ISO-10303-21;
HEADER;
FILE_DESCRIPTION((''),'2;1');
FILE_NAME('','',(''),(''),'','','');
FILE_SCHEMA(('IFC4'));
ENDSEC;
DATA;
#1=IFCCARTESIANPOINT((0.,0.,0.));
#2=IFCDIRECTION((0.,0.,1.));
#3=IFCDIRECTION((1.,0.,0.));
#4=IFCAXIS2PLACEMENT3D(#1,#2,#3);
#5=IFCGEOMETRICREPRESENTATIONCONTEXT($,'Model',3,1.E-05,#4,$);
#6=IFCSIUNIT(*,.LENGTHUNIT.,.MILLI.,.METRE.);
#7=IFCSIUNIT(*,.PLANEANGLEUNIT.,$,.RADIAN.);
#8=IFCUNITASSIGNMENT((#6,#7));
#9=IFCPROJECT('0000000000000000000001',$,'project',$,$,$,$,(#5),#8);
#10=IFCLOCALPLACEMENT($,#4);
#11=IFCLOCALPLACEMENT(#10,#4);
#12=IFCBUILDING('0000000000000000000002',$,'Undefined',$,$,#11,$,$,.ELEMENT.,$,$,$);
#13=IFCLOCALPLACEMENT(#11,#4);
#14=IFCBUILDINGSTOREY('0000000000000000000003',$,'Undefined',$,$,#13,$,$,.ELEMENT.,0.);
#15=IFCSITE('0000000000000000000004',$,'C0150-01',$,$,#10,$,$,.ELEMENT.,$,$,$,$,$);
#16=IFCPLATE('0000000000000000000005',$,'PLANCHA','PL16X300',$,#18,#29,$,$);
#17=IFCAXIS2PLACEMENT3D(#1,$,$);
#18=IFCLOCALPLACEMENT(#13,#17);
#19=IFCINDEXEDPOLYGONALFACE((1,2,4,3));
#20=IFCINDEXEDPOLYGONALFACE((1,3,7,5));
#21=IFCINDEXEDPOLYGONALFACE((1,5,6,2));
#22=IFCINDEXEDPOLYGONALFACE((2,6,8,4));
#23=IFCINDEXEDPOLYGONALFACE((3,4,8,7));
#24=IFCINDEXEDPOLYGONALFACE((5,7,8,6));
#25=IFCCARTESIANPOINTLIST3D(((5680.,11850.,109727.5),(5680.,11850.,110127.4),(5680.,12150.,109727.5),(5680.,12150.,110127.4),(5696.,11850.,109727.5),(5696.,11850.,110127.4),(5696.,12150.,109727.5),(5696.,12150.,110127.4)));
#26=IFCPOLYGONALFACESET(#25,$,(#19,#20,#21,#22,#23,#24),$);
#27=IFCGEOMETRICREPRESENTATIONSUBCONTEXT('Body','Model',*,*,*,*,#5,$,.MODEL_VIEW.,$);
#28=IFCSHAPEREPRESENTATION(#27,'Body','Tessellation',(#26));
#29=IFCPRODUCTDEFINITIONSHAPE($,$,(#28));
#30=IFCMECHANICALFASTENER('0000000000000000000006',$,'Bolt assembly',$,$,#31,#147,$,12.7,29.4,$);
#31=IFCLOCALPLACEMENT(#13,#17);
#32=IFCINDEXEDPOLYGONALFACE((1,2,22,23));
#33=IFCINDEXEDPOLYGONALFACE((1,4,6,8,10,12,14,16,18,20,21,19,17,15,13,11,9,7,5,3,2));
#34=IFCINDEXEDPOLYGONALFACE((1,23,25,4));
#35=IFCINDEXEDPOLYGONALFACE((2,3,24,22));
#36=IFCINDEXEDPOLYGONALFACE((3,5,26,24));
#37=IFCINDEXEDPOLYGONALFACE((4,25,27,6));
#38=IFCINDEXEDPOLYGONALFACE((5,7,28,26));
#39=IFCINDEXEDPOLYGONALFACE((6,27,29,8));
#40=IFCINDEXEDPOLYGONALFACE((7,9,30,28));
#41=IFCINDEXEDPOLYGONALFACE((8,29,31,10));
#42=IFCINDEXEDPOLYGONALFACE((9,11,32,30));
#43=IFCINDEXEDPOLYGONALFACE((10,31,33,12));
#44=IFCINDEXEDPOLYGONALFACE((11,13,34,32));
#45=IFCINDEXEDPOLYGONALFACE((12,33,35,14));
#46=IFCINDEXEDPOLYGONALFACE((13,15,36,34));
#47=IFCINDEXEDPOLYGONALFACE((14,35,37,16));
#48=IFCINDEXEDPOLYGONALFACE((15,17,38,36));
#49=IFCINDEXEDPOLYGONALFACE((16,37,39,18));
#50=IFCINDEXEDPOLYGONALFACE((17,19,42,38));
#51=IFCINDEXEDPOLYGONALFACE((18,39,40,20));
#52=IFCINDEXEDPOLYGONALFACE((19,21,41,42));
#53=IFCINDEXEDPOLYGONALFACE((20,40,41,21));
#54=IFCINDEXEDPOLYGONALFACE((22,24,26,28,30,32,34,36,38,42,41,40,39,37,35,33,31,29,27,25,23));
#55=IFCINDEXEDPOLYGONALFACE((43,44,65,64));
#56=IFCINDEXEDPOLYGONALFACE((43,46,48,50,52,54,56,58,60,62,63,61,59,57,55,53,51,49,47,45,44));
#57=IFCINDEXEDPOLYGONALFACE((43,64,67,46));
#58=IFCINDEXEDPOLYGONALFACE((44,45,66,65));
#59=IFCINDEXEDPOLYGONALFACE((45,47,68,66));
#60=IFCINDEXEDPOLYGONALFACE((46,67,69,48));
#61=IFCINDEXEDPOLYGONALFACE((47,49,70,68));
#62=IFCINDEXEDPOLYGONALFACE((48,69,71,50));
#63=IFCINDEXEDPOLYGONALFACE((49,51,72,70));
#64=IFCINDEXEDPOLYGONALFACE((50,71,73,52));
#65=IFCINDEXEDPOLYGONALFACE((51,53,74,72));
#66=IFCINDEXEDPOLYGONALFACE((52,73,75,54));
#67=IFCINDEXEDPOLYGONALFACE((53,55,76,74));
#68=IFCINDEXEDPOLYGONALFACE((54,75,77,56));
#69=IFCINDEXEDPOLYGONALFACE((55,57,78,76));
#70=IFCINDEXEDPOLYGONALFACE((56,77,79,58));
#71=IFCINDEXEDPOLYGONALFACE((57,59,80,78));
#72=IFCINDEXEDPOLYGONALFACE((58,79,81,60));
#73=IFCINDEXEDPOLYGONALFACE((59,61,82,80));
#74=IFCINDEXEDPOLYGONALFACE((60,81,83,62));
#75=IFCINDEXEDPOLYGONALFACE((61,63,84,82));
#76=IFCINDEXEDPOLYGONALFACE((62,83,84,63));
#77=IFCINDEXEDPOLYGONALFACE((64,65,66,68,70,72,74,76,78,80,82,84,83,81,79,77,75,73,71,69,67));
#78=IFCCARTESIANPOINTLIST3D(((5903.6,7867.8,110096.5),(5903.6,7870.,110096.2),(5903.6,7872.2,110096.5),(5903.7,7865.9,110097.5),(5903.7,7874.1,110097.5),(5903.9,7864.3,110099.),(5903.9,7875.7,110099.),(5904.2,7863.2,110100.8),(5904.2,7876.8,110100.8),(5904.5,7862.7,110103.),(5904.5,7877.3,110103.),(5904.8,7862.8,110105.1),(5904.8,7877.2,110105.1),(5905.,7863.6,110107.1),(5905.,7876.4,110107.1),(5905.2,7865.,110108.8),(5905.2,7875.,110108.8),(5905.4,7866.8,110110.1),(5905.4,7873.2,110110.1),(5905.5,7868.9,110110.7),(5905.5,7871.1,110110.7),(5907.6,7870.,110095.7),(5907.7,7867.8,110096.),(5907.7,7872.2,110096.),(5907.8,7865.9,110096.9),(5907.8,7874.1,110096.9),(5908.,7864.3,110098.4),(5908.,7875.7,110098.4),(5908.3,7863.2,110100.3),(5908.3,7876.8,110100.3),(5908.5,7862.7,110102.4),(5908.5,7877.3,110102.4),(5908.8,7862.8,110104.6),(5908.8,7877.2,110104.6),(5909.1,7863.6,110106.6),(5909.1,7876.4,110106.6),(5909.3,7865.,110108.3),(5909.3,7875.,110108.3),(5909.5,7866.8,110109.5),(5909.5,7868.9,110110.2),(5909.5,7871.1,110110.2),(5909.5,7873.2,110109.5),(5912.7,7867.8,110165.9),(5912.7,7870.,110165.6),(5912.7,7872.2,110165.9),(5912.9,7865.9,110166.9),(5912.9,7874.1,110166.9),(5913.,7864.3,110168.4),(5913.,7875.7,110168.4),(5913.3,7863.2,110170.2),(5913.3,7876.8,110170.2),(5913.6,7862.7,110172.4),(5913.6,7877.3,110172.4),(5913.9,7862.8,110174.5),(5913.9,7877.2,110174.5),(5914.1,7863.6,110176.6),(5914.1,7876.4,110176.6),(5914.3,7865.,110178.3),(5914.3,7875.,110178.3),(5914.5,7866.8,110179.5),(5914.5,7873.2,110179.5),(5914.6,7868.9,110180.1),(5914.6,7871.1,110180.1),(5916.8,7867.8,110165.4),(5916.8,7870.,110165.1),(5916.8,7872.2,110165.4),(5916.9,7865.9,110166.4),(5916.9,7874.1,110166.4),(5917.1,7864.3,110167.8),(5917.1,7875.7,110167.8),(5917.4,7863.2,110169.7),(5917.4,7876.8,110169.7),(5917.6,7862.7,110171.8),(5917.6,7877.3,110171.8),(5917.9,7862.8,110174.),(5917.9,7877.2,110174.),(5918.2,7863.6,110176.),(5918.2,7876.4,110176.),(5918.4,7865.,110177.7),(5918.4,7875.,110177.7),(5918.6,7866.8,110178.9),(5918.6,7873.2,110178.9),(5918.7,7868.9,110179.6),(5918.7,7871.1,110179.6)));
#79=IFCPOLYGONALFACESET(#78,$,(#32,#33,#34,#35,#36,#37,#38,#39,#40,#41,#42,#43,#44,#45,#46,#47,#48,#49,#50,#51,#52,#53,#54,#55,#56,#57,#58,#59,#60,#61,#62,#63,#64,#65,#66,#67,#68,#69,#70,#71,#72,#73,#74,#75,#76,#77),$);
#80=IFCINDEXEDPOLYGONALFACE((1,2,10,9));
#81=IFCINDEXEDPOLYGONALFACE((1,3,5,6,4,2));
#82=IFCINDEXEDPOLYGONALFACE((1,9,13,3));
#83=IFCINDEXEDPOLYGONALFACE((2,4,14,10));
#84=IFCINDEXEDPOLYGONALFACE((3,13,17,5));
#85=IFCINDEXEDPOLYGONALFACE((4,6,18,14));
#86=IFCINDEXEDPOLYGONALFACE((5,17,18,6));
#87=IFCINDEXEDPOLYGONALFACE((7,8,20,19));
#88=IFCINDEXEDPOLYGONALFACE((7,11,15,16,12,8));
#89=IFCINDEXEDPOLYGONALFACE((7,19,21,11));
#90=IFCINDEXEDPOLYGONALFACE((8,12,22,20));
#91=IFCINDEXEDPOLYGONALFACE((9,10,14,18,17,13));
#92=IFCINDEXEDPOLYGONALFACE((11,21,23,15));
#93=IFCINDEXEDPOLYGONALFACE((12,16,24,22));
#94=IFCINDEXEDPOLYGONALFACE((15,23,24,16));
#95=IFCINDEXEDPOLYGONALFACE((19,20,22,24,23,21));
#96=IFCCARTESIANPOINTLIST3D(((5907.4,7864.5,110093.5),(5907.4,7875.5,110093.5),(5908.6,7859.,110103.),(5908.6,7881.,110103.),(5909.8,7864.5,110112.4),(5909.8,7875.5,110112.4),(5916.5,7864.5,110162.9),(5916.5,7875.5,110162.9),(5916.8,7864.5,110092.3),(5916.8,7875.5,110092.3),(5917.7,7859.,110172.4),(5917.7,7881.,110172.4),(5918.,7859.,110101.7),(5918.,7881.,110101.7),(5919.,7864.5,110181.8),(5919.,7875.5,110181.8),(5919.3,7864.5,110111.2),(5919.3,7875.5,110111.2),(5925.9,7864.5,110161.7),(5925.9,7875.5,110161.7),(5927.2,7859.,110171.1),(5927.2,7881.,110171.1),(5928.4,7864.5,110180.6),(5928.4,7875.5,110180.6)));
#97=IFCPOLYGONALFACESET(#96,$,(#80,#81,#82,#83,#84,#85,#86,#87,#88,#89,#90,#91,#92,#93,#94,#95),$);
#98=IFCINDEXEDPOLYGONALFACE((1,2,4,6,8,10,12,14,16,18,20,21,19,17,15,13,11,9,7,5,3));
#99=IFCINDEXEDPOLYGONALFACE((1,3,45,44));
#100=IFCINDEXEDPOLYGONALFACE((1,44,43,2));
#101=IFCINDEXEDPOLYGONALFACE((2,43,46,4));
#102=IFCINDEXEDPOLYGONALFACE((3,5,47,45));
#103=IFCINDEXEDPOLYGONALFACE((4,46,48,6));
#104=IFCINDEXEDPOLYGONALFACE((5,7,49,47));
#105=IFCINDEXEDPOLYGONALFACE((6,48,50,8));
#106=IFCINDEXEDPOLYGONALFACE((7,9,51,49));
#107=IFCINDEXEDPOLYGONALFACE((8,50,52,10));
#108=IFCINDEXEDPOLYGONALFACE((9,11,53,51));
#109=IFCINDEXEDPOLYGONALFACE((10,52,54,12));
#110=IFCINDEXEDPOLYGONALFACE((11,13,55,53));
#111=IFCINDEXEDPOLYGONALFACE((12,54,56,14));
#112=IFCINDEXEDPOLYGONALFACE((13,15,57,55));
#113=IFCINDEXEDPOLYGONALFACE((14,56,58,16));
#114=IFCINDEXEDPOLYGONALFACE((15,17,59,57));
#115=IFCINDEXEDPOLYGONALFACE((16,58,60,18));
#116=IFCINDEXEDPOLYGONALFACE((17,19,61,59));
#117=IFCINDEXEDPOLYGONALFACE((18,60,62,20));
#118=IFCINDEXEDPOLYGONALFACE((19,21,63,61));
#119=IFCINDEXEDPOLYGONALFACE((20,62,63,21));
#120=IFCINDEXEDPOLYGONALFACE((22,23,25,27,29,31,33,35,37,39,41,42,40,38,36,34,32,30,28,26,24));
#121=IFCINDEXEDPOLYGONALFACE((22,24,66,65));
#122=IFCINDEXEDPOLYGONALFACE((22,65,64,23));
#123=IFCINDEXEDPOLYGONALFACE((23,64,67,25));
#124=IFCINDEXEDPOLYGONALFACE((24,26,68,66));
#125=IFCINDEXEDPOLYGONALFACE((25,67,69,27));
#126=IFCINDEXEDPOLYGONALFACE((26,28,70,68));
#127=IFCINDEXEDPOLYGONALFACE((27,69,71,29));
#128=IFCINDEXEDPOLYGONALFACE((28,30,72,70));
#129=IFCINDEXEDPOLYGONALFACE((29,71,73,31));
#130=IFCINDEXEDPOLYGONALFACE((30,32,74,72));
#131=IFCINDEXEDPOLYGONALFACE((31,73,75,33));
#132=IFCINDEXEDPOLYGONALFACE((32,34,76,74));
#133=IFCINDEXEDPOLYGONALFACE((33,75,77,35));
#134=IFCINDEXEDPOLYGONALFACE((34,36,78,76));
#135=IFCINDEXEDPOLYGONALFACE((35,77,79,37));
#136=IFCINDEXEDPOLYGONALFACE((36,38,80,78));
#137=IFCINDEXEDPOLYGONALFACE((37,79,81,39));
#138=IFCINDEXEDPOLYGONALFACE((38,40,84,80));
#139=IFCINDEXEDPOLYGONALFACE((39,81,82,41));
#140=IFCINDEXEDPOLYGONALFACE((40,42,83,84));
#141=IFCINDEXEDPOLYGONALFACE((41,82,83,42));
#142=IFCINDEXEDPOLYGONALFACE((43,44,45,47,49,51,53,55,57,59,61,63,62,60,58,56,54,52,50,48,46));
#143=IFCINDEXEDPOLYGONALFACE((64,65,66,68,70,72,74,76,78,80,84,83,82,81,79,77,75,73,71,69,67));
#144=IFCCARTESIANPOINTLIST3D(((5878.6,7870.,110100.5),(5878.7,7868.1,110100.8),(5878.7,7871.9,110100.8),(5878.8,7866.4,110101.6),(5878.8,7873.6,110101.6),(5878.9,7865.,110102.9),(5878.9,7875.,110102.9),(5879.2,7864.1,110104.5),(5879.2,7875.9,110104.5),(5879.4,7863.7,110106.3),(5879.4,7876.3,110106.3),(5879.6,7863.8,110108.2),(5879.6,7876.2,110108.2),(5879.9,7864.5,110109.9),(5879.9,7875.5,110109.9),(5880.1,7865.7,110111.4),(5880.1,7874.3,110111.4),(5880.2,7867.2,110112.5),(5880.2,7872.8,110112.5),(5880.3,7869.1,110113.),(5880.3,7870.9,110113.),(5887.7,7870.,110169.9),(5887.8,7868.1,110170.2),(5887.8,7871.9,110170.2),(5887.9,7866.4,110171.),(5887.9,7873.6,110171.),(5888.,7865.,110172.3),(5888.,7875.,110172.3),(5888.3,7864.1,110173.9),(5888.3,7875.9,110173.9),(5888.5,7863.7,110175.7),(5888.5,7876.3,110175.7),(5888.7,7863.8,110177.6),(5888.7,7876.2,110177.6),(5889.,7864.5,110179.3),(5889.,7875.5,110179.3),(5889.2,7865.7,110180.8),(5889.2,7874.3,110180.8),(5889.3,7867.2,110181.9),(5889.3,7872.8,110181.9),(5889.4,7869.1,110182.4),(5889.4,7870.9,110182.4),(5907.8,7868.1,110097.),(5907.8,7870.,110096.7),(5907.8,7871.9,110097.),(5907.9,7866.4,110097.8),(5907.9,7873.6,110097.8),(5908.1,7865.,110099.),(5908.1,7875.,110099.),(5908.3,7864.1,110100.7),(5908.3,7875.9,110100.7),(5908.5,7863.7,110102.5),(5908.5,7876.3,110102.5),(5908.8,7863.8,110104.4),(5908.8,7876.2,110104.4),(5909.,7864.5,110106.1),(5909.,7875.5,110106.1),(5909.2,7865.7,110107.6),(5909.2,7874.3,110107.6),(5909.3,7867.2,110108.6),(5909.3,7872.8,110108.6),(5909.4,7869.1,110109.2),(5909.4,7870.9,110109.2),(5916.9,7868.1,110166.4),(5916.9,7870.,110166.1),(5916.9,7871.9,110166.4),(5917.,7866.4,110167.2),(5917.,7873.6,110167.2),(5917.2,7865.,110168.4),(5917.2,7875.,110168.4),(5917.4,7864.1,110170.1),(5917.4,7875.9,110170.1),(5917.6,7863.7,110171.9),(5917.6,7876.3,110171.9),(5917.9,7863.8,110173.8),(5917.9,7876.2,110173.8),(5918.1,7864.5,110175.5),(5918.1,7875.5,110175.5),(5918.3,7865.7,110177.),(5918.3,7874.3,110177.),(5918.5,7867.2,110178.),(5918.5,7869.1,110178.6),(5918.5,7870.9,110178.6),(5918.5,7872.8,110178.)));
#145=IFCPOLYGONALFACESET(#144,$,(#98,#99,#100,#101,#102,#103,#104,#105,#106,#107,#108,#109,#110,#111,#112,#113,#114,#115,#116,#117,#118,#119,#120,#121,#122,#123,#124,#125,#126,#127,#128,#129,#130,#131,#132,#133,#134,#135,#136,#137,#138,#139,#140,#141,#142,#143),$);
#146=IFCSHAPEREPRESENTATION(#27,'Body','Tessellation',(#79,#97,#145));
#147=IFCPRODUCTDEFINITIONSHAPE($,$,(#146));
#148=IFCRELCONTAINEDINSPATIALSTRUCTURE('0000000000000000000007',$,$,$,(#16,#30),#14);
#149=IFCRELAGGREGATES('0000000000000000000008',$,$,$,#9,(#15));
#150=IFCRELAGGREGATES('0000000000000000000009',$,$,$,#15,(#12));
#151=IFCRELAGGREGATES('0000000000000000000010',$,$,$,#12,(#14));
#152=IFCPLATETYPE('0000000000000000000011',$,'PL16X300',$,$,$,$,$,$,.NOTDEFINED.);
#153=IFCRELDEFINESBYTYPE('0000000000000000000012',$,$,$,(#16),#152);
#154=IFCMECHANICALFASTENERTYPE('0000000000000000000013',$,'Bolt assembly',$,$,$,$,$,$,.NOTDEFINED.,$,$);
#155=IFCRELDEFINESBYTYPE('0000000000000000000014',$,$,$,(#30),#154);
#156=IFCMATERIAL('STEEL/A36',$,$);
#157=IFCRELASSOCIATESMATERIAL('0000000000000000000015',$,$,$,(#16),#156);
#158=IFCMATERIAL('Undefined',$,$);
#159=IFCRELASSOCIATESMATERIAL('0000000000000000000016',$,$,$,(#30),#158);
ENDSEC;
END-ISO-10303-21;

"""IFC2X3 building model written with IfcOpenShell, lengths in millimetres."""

from ifc_helpers import new_model, si_unit, frame, origin_with_axes, origin_2d_with_axis, place, context, subcontext, project, spatial, polyline, circle, outline, extrude, source, transform, mapped, material, type_object, element, save


model = new_model("IFC2X3")

# Units and contexts
model_context = context("Model", 3, precision=1e-05, world=origin_with_axes())
body_context = subcontext(model_context, "Body", "Model", "MODEL_VIEW")
ifc_project = project(units=[si_unit("LENGTHUNIT", "METRE", prefix="MILLI"), si_unit("PLANEANGLEUNIT", "RADIAN")], contexts=[model_context])

# Site, building, storey
site_placement = place(None, origin_with_axes())
site = spatial("IfcSite", under=ifc_project, at=site_placement, Name="C0150-01", CompositionType="ELEMENT")
building_placement = place(site_placement, origin_with_axes())
building = spatial("IfcBuilding", under=site, at=building_placement, Name="Undefined", CompositionType="ELEMENT")
storey_placement = place(building_placement, origin_with_axes())
storey = spatial("IfcBuildingStorey", under=building, at=storey_placement, Name="Undefined", CompositionType="ELEMENT", Elevation=0.0)

# Shared definitions
ifc_material_1 = material(Name="STEEL/A36")

# Plate
plate_type_1 = type_object("IfcPlateType", Name="PL16X300", PredefinedType="NOTDEFINED")
plate_1_placement = place(storey_placement, frame((5688.0, 11850.0, 109727.5), z_axis=(1.0, 0.0, 0.0), x_axis=(0.0, 1.0, 0.0)))
element("IfcPlate", 1, at=plate_1_placement, inside=storey, type_object=plate_type_1, material=ifc_material_1, Name="PLANCHA", Description="PL16X300", context=body_context, shape_type="SweptSolid", body=[
    extrude(outline(polyline([(0.0, 0.0), (300.0, 0.0), (300.0, 399.9), (0.0, 399.9), (0.0, 0.0)])), frame((0.0, 0.0, -8.0), z_axis=(0.0, 0.0, 1.0), x_axis=(1.0, 0.0, 0.0)), (0.0, 0.0, 1.0), 16.0),
])

# Mechanical fastener
ifc_material_2 = material(Name="Undefined")
mechanical_fastener_type = type_object("IfcMechanicalFastenerType", Name="Bolt assembly")
shared_shape_1 = source(origin_with_axes(), body_context, "Body", "SweptSolid", [
    extrude(circle(Radius=7.3, at=origin_2d_with_axis()), frame((0.0, 0.0, 0.0), z_axis=(0.0, 1.0, 0.0), x_axis=(1.0, 0.0, 0.0)), (0.0, 0.0, 1.0), 4.1),
    extrude(outline(polyline([(9.5, -5.5), (9.5, 5.5), (0.0, 11.0), (-9.5, 5.5), (-9.5, -5.5), (0.0, -11.0), (9.5, -5.5)])), frame((0.0, -9.5, 0.0), z_axis=(0.0, 1.0, 0.0), x_axis=(1.0, 0.0, 0.0)), (0.0, 0.0, 1.0), 9.5),
    extrude(circle(Radius=6.3, at=origin_2d_with_axis()), frame((0.0, 0.0, 0.0), z_axis=(0.0, 1.0, 0.0), x_axis=(1.0, 0.0, 0.0)), (0.0, 0.0, 1.0), 29.4),
])
for number, where, z_axis, x_axis, name in (
    (2, (5917.7, 7870.0, 110172.4), (0.0, 1.0, 0.0), (-0.130054, 0.0, -0.991507), "Bolt assembly"),
):
    element("IfcMechanicalFastener", number, at=place(storey_placement, frame(where, z_axis=z_axis, x_axis=x_axis)), inside=storey, type_object=mechanical_fastener_type, material=ifc_material_2, Name=name, NominalDiameter=12.7, NominalLength=29.4, context=body_context, shape_type="MappedRepresentation", body=[
        mapped(shared_shape_1, transform((0.0, 0.0, 0.0))),
        mapped(shared_shape_1, transform((70.0, 0.0, 0.0))),
    ])

save(model, "model.ifc")
